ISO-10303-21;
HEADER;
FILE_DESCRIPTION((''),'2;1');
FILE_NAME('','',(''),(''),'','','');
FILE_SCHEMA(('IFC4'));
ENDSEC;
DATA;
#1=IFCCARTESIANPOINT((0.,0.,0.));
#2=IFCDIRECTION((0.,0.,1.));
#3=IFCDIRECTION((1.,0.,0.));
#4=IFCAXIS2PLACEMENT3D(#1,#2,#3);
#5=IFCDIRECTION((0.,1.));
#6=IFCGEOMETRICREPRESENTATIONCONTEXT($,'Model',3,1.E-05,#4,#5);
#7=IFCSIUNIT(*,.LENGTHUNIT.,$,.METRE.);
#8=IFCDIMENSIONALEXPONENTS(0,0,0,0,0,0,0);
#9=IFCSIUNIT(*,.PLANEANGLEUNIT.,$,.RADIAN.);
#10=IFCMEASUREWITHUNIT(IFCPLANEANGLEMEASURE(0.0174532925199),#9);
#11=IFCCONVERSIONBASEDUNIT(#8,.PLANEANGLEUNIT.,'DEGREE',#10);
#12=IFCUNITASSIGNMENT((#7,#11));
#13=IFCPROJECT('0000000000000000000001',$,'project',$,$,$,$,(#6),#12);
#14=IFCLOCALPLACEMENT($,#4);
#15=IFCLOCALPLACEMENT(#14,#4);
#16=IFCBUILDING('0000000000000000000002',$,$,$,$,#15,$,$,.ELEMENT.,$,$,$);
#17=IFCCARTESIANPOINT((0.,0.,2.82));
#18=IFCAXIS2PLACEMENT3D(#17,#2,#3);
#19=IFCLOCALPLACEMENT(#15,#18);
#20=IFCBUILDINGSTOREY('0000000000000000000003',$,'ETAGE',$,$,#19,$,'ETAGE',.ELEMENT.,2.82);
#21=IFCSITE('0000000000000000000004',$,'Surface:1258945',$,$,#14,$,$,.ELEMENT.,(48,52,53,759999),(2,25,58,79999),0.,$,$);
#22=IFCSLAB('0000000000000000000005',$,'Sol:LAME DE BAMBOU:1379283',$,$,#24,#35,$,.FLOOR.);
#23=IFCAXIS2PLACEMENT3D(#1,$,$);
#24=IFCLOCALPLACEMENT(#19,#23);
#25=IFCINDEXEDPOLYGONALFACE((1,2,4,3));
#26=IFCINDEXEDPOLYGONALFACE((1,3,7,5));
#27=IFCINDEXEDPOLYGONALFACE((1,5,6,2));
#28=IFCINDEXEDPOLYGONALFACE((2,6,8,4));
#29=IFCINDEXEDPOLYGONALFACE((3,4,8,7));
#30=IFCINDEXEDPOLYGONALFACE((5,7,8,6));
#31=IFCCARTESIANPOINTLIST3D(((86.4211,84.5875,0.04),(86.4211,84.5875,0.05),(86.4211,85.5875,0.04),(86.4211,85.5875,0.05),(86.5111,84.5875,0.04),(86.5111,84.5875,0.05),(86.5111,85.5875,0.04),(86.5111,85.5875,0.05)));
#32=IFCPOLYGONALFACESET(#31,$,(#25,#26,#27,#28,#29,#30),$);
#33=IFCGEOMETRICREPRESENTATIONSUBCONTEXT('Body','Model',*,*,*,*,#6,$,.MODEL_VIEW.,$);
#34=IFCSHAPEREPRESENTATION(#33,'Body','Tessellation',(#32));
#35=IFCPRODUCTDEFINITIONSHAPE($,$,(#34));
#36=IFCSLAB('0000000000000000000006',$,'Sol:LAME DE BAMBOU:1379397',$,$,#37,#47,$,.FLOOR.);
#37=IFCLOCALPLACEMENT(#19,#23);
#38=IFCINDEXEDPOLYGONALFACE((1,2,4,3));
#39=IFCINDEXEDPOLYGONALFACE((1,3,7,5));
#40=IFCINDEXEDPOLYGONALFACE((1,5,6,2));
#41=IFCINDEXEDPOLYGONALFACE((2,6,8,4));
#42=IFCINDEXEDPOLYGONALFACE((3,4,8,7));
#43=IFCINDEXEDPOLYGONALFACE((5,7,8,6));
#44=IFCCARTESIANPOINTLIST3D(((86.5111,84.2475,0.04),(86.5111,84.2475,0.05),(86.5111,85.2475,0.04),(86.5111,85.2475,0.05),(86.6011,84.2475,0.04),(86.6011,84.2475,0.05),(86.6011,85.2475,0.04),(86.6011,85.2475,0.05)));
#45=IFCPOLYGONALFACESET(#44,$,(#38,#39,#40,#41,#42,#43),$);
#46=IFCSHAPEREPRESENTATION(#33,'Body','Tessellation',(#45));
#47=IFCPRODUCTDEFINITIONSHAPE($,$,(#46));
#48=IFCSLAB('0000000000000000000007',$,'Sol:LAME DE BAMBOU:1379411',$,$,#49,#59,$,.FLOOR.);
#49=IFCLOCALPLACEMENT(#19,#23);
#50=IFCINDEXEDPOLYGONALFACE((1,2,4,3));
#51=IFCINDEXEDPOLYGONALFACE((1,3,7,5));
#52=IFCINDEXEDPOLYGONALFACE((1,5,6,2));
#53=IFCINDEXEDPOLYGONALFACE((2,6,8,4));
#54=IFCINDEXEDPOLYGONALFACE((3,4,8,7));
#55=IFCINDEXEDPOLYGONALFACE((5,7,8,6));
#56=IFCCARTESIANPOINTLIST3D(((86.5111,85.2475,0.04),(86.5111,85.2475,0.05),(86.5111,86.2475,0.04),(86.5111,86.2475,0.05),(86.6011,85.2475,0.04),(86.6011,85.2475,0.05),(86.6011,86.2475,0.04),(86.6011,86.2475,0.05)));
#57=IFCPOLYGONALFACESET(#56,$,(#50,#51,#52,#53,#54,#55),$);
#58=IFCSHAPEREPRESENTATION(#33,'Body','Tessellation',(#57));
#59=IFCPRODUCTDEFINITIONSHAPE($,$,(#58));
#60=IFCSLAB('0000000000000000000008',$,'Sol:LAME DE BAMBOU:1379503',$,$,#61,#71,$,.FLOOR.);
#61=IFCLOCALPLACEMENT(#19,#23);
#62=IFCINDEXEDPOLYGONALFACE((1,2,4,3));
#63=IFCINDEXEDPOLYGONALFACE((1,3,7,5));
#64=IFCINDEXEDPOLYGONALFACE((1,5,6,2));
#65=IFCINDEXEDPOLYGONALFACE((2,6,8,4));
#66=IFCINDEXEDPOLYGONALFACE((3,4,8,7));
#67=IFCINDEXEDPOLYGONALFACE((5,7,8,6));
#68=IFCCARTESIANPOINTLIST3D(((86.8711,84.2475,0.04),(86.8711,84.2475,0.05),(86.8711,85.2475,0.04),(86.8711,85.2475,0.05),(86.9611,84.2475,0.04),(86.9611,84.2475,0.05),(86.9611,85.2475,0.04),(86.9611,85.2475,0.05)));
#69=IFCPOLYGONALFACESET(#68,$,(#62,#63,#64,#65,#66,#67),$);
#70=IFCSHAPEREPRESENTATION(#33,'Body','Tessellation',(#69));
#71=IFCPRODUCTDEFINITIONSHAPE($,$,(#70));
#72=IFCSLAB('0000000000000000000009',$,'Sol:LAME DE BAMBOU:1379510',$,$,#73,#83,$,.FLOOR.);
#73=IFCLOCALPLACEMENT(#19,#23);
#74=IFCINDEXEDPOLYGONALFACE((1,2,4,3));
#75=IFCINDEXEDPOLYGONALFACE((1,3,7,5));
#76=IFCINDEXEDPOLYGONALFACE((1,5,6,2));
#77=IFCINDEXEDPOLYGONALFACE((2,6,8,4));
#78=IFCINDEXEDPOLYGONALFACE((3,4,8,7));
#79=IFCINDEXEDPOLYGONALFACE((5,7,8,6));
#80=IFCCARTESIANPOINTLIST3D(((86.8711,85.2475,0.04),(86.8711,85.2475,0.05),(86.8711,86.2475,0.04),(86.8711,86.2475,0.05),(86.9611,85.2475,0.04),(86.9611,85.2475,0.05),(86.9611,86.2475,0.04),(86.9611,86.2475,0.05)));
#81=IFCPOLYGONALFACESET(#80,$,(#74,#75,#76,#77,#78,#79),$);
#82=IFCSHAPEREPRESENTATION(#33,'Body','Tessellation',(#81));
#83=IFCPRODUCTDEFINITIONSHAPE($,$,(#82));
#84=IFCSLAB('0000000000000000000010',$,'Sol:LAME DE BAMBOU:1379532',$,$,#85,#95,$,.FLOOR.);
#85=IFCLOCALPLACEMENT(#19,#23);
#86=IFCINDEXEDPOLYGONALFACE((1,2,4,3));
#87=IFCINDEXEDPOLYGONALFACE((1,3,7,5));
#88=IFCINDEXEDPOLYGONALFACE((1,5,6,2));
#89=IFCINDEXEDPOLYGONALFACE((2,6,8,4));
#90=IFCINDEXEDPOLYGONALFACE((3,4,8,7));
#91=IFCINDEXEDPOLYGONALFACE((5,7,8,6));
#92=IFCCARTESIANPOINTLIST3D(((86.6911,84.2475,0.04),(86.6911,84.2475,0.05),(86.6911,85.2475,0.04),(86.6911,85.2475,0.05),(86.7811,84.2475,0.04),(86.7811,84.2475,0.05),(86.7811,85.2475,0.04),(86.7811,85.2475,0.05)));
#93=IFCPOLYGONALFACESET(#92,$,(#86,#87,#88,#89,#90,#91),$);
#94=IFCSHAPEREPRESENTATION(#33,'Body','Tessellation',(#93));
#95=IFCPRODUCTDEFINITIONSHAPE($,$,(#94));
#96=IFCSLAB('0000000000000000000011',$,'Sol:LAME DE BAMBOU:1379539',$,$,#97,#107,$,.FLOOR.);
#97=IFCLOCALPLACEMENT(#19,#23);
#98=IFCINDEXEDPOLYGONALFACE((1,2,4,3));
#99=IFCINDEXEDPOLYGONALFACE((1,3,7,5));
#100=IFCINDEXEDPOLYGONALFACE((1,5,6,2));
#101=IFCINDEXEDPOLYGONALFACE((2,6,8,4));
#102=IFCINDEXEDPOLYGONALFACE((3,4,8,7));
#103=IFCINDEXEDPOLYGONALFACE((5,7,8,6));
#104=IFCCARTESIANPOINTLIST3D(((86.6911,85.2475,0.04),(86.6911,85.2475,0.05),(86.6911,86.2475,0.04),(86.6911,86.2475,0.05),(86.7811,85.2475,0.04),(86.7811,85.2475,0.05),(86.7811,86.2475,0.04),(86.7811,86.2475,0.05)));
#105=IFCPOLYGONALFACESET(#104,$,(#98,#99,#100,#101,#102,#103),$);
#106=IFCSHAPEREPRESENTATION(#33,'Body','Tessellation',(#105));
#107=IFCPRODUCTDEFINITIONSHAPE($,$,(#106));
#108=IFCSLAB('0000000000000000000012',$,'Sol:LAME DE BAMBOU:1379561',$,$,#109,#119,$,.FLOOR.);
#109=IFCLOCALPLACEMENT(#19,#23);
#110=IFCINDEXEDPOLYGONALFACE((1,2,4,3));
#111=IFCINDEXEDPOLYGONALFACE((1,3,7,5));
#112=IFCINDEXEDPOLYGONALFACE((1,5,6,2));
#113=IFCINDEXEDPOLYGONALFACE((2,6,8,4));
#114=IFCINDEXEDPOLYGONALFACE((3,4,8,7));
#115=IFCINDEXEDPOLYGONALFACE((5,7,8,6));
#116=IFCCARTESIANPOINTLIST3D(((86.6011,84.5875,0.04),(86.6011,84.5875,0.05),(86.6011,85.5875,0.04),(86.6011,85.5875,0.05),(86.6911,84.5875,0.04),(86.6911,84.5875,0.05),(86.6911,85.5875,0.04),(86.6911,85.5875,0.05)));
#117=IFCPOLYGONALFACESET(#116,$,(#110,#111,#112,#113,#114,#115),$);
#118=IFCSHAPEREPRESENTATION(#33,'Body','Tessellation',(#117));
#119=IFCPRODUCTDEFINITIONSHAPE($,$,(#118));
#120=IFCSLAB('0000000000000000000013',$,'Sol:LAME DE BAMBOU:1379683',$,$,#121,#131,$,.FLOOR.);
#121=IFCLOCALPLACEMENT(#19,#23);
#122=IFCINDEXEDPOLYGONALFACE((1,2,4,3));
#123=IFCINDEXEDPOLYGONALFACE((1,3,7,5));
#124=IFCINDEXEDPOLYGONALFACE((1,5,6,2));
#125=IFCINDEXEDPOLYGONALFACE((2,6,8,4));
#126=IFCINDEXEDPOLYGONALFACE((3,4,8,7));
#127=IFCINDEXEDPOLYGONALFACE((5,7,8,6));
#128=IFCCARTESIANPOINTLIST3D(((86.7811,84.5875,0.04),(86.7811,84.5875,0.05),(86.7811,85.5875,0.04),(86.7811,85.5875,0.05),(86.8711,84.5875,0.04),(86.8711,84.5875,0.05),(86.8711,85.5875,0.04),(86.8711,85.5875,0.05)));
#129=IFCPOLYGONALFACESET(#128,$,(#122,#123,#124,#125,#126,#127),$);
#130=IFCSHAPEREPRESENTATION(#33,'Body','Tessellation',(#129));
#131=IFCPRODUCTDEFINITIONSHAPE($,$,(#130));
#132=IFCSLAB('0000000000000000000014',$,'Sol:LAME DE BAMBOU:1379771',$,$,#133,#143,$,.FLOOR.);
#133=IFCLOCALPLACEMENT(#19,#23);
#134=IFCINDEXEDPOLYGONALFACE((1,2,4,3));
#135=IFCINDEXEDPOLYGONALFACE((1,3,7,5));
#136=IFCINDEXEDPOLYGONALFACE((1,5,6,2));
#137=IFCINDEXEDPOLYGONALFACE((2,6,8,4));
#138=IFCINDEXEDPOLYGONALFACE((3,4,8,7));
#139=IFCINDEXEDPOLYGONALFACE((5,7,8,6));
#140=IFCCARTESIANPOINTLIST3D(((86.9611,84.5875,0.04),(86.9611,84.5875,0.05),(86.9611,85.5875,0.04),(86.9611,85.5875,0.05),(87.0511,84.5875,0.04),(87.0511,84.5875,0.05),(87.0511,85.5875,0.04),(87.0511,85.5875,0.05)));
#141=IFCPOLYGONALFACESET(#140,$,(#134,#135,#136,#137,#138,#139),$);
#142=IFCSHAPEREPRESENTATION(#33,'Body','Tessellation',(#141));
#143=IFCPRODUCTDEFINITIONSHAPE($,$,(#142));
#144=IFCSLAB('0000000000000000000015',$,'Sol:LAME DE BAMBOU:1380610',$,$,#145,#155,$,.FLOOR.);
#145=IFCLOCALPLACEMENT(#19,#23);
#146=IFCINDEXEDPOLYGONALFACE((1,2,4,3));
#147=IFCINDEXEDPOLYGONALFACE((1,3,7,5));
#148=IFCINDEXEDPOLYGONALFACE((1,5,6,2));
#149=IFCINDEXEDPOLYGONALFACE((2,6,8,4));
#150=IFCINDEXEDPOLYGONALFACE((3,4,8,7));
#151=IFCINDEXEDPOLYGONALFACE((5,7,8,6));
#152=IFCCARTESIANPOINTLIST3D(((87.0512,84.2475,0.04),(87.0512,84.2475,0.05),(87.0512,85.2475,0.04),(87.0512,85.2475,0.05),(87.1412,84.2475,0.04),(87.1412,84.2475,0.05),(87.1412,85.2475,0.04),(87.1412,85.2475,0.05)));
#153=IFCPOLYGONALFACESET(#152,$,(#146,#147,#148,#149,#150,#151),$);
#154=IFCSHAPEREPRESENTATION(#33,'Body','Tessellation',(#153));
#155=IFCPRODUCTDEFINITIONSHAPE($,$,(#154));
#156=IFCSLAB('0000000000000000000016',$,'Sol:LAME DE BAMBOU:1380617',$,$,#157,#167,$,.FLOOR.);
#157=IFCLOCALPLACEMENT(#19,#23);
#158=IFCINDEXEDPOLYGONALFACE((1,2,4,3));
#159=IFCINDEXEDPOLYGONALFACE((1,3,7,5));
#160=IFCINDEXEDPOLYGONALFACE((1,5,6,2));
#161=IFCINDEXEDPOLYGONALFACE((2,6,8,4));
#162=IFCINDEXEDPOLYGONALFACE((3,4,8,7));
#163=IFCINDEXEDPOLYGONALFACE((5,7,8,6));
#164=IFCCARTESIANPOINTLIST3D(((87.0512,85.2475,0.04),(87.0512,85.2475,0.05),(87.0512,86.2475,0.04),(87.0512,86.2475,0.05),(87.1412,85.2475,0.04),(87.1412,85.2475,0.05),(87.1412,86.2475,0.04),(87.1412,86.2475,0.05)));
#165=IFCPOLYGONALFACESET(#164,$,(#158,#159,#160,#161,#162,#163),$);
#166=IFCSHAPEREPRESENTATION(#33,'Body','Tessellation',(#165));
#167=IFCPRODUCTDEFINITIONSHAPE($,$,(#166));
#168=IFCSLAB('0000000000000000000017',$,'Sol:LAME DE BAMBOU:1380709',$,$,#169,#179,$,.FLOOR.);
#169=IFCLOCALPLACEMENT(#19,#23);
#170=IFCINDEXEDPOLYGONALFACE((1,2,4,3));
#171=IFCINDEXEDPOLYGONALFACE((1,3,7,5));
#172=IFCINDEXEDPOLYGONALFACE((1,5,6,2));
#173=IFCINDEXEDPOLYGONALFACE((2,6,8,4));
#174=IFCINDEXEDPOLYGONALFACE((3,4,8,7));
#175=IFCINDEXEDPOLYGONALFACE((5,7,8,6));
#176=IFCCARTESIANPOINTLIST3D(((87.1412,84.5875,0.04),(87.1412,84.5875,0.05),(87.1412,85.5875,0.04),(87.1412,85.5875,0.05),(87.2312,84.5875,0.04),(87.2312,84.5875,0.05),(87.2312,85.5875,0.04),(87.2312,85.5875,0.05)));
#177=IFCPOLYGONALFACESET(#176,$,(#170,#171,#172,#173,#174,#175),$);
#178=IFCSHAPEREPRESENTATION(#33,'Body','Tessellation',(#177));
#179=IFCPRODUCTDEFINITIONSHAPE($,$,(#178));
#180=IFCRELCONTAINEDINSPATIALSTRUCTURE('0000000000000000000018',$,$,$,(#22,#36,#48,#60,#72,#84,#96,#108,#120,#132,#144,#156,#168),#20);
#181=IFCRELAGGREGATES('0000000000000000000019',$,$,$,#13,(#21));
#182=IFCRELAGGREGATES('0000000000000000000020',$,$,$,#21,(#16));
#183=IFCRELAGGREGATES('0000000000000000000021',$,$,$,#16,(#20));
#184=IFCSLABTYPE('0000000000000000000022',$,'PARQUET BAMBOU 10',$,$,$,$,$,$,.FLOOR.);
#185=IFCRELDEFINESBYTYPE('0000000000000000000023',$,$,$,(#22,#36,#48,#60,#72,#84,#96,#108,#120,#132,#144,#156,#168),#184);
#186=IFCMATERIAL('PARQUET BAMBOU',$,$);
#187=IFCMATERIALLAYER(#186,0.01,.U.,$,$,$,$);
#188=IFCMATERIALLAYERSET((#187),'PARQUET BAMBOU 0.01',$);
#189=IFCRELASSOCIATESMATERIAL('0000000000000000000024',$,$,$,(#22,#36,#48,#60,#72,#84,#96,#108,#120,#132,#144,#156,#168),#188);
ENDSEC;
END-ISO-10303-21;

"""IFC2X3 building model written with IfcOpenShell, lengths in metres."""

from ifc_helpers import new_model, entity, si_unit, converted_unit, direction, frame, origin_with_axes, place, context, subcontext, project, spatial, polyline, outline, extrude, material, layer, layer_set, layer_usage, type_object, element, save


model = new_model("IFC2X3")

# Units and contexts
model_context = context("Model", 3, precision=1e-05, world=origin_with_axes(), true_north=direction((0.0, 1.0)))
body_context = subcontext(model_context, "Body", "Model", "MODEL_VIEW")
ifc_project = project(units=[si_unit("LENGTHUNIT", "METRE"), converted_unit("PLANEANGLEUNIT", "DEGREE", entity("IfcPlaneAngleMeasure", 0.0174532925199), si_unit("PLANEANGLEUNIT", "RADIAN"), dimensions=[0, 0, 0, 0, 0, 0, 0])], contexts=[model_context])

# Site, building, storey
site_placement = place(None, origin_with_axes())
site = spatial("IfcSite", under=ifc_project, at=site_placement, Name="Surface:1258945", CompositionType="ELEMENT", RefLatitude=(48, 52, 53, 759999), RefLongitude=(2, 25, 58, 79999), RefElevation=0.0)
building_placement = place(site_placement, origin_with_axes())
building = spatial("IfcBuilding", under=site, at=building_placement, CompositionType="ELEMENT")
storey_placement = place(building_placement, frame((0.0, 0.0, 2.82), z_axis=(0.0, 0.0, 1.0), x_axis=(1.0, 0.0, 0.0)))
storey = spatial("IfcBuildingStorey", under=building, at=storey_placement, Name="ETAGE", LongName="ETAGE", CompositionType="ELEMENT", Elevation=2.82)

# Slabs
ifc_material_1 = material(Name="PARQUET BAMBOU")
ifc_layer_1 = layer(ifc_material_1, 0.01, ventilated="UNKNOWN")
ifc_layer_set_1 = layer_set([ifc_layer_1], Name="PARQUET BAMBOU 0.01")
ifc_layer_usage_1 = layer_usage(ifc_layer_set_1, "AXIS3", "NEGATIVE", 0.01)
slab_type = type_object("IfcSlabType", Name="PARQUET BAMBOU 10", PredefinedType="FLOOR")
slab_1_placement = place(storey_placement, frame((86.4211, 85.5875, 0.05), z_axis=(0.0, 0.0, 1.0), x_axis=(1.0, 0.0, 0.0)))
element("IfcSlab", 1, at=slab_1_placement, inside=storey, type_object=slab_type, material=ifc_layer_usage_1, Name="Sol:LAME DE BAMBOU:1379283", PredefinedType="FLOOR", context=body_context, shape_type="SweptSolid", body=[
    extrude(outline(polyline([(0.0, 0.0), (0.0, -1.0), (0.09, -1.0), (0.09, 0.0), (0.0, 0.0)])), frame((0.0, 0.0, -0.01), z_axis=(0.0, 0.0, 1.0), x_axis=(1.0, 0.0, 0.0)), (0.0, 0.0, 1.0), 0.01),
])
ifc_layer_usage_2 = layer_usage(ifc_layer_set_1, "AXIS3", "NEGATIVE", 0.01)
slab_2_placement = place(storey_placement, frame((86.5111, 85.2475, 0.05), z_axis=(0.0, 0.0, 1.0), x_axis=(1.0, 0.0, 0.0)))
element("IfcSlab", 2, at=slab_2_placement, inside=storey, type_object=slab_type, material=ifc_layer_usage_2, Name="Sol:LAME DE BAMBOU:1379397", PredefinedType="FLOOR", context=body_context, shape_type="SweptSolid", body=[
    extrude(outline(polyline([(0.0, 0.0), (0.0, -1.0), (0.09, -1.0), (0.09, 0.0), (0.0, 0.0)])), frame((0.0, 0.0, -0.01), z_axis=(0.0, 0.0, 1.0), x_axis=(1.0, 0.0, 0.0)), (0.0, 0.0, 1.0), 0.01),
])
ifc_layer_usage_3 = layer_usage(ifc_layer_set_1, "AXIS3", "NEGATIVE", 0.01)
slab_3_placement = place(storey_placement, frame((86.5111, 86.2475, 0.05), z_axis=(0.0, 0.0, 1.0), x_axis=(1.0, 0.0, 0.0)))
element("IfcSlab", 3, at=slab_3_placement, inside=storey, type_object=slab_type, material=ifc_layer_usage_3, Name="Sol:LAME DE BAMBOU:1379411", PredefinedType="FLOOR", context=body_context, shape_type="SweptSolid", body=[
    extrude(outline(polyline([(0.0, 0.0), (0.0, -1.0), (0.09, -1.0), (0.09, 0.0), (0.0, 0.0)])), frame((0.0, 0.0, -0.01), z_axis=(0.0, 0.0, 1.0), x_axis=(1.0, 0.0, 0.0)), (0.0, 0.0, 1.0), 0.01),
])
ifc_layer_usage_4 = layer_usage(ifc_layer_set_1, "AXIS3", "NEGATIVE", 0.01)
slab_4_placement = place(storey_placement, frame((86.8711, 85.2475, 0.05), z_axis=(0.0, 0.0, 1.0), x_axis=(1.0, 0.0, 0.0)))
element("IfcSlab", 4, at=slab_4_placement, inside=storey, type_object=slab_type, material=ifc_layer_usage_4, Name="Sol:LAME DE BAMBOU:1379503", PredefinedType="FLOOR", context=body_context, shape_type="SweptSolid", body=[
    extrude(outline(polyline([(0.0, 0.0), (0.0, -1.0), (0.09, -1.0), (0.09, 0.0), (0.0, 0.0)])), frame((0.0, 0.0, -0.01), z_axis=(0.0, 0.0, 1.0), x_axis=(1.0, 0.0, 0.0)), (0.0, 0.0, 1.0), 0.01),
])
ifc_layer_usage_5 = layer_usage(ifc_layer_set_1, "AXIS3", "NEGATIVE", 0.01)
slab_5_placement = place(storey_placement, frame((86.8711, 86.2475, 0.05), z_axis=(0.0, 0.0, 1.0), x_axis=(1.0, 0.0, 0.0)))
element("IfcSlab", 5, at=slab_5_placement, inside=storey, type_object=slab_type, material=ifc_layer_usage_5, Name="Sol:LAME DE BAMBOU:1379510", PredefinedType="FLOOR", context=body_context, shape_type="SweptSolid", body=[
    extrude(outline(polyline([(0.0, 0.0), (0.0, -1.0), (0.09, -1.0), (0.09, 0.0), (0.0, 0.0)])), frame((0.0, 0.0, -0.01), z_axis=(0.0, 0.0, 1.0), x_axis=(1.0, 0.0, 0.0)), (0.0, 0.0, 1.0), 0.01),
])
ifc_layer_usage_6 = layer_usage(ifc_layer_set_1, "AXIS3", "NEGATIVE", 0.01)
slab_6_placement = place(storey_placement, frame((86.6911, 85.2475, 0.05), z_axis=(0.0, 0.0, 1.0), x_axis=(1.0, 0.0, 0.0)))
element("IfcSlab", 6, at=slab_6_placement, inside=storey, type_object=slab_type, material=ifc_layer_usage_6, Name="Sol:LAME DE BAMBOU:1379532", PredefinedType="FLOOR", context=body_context, shape_type="SweptSolid", body=[
    extrude(outline(polyline([(0.0, 0.0), (0.0, -1.0), (0.09, -1.0), (0.09, 0.0), (0.0, 0.0)])), frame((0.0, 0.0, -0.01), z_axis=(0.0, 0.0, 1.0), x_axis=(1.0, 0.0, 0.0)), (0.0, 0.0, 1.0), 0.01),
])
ifc_layer_usage_7 = layer_usage(ifc_layer_set_1, "AXIS3", "NEGATIVE", 0.01)
slab_7_placement = place(storey_placement, frame((86.6911, 86.2475, 0.05), z_axis=(0.0, 0.0, 1.0), x_axis=(1.0, 0.0, 0.0)))
element("IfcSlab", 7, at=slab_7_placement, inside=storey, type_object=slab_type, material=ifc_layer_usage_7, Name="Sol:LAME DE BAMBOU:1379539", PredefinedType="FLOOR", context=body_context, shape_type="SweptSolid", body=[
    extrude(outline(polyline([(0.0, 0.0), (0.0, -1.0), (0.09, -1.0), (0.09, 0.0), (0.0, 0.0)])), frame((0.0, 0.0, -0.01), z_axis=(0.0, 0.0, 1.0), x_axis=(1.0, 0.0, 0.0)), (0.0, 0.0, 1.0), 0.01),
])
ifc_layer_usage_8 = layer_usage(ifc_layer_set_1, "AXIS3", "NEGATIVE", 0.01)
slab_8_placement = place(storey_placement, frame((86.6011, 85.5875, 0.05), z_axis=(0.0, 0.0, 1.0), x_axis=(1.0, 0.0, 0.0)))
element("IfcSlab", 8, at=slab_8_placement, inside=storey, type_object=slab_type, material=ifc_layer_usage_8, Name="Sol:LAME DE BAMBOU:1379561", PredefinedType="FLOOR", context=body_context, shape_type="SweptSolid", body=[
    extrude(outline(polyline([(0.0, 0.0), (0.0, -1.0), (0.09, -1.0), (0.09, 0.0), (0.0, 0.0)])), frame((0.0, 0.0, -0.01), z_axis=(0.0, 0.0, 1.0), x_axis=(1.0, 0.0, 0.0)), (0.0, 0.0, 1.0), 0.01),
])
ifc_layer_usage_9 = layer_usage(ifc_layer_set_1, "AXIS3", "NEGATIVE", 0.01)
slab_9_placement = place(storey_placement, frame((86.7811, 85.5875, 0.05), z_axis=(0.0, 0.0, 1.0), x_axis=(1.0, 0.0, 0.0)))
element("IfcSlab", 9, at=slab_9_placement, inside=storey, type_object=slab_type, material=ifc_layer_usage_9, Name="Sol:LAME DE BAMBOU:1379683", PredefinedType="FLOOR", context=body_context, shape_type="SweptSolid", body=[
    extrude(outline(polyline([(0.0, 0.0), (0.0, -1.0), (0.09, -1.0), (0.09, 0.0), (0.0, 0.0)])), frame((0.0, 0.0, -0.01), z_axis=(0.0, 0.0, 1.0), x_axis=(1.0, 0.0, 0.0)), (0.0, 0.0, 1.0), 0.01),
])
ifc_layer_usage_10 = layer_usage(ifc_layer_set_1, "AXIS3", "NEGATIVE", 0.01)
slab_10_placement = place(storey_placement, frame((86.9611, 85.5875, 0.05), z_axis=(0.0, 0.0, 1.0), x_axis=(1.0, 0.0, 0.0)))
element("IfcSlab", 10, at=slab_10_placement, inside=storey, type_object=slab_type, material=ifc_layer_usage_10, Name="Sol:LAME DE BAMBOU:1379771", PredefinedType="FLOOR", context=body_context, shape_type="SweptSolid", body=[
    extrude(outline(polyline([(0.0, 0.0), (0.0, -1.0), (0.09, -1.0), (0.09, 0.0), (0.0, 0.0)])), frame((0.0, 0.0, -0.01), z_axis=(0.0, 0.0, 1.0), x_axis=(1.0, 0.0, 0.0)), (0.0, 0.0, 1.0), 0.01),
])
ifc_layer_usage_11 = layer_usage(ifc_layer_set_1, "AXIS3", "NEGATIVE", 0.01)
slab_11_placement = place(storey_placement, frame((87.0512, 85.2475, 0.05), z_axis=(0.0, 0.0, 1.0), x_axis=(1.0, 0.0, 0.0)))
element("IfcSlab", 11, at=slab_11_placement, inside=storey, type_object=slab_type, material=ifc_layer_usage_11, Name="Sol:LAME DE BAMBOU:1380610", PredefinedType="FLOOR", context=body_context, shape_type="SweptSolid", body=[
    extrude(outline(polyline([(0.0, 0.0), (0.0, -1.0), (0.09, -1.0), (0.09, 0.0), (0.0, 0.0)])), frame((0.0, 0.0, -0.01), z_axis=(0.0, 0.0, 1.0), x_axis=(1.0, 0.0, 0.0)), (0.0, 0.0, 1.0), 0.01),
])
ifc_layer_usage_12 = layer_usage(ifc_layer_set_1, "AXIS3", "NEGATIVE", 0.01)
slab_12_placement = place(storey_placement, frame((87.0512, 86.2475, 0.05), z_axis=(0.0, 0.0, 1.0), x_axis=(1.0, 0.0, 0.0)))
element("IfcSlab", 12, at=slab_12_placement, inside=storey, type_object=slab_type, material=ifc_layer_usage_12, Name="Sol:LAME DE BAMBOU:1380617", PredefinedType="FLOOR", context=body_context, shape_type="SweptSolid", body=[
    extrude(outline(polyline([(0.0, 0.0), (0.0, -1.0), (0.09, -1.0), (0.09, 0.0), (0.0, 0.0)])), frame((0.0, 0.0, -0.01), z_axis=(0.0, 0.0, 1.0), x_axis=(1.0, 0.0, 0.0)), (0.0, 0.0, 1.0), 0.01),
])
ifc_layer_usage_13 = layer_usage(ifc_layer_set_1, "AXIS3", "NEGATIVE", 0.01)
slab_13_placement = place(storey_placement, frame((87.1412, 85.5875, 0.05), z_axis=(0.0, 0.0, 1.0), x_axis=(1.0, 0.0, 0.0)))
element("IfcSlab", 13, at=slab_13_placement, inside=storey, type_object=slab_type, material=ifc_layer_usage_13, Name="Sol:LAME DE BAMBOU:1380709", PredefinedType="FLOOR", context=body_context, shape_type="SweptSolid", body=[
    extrude(outline(polyline([(0.0, 0.0), (0.0, -1.0), (0.09, -1.0), (0.09, 0.0), (0.0, 0.0)])), frame((0.0, 0.0, -0.01), z_axis=(0.0, 0.0, 1.0), x_axis=(1.0, 0.0, 0.0)), (0.0, 0.0, 1.0), 0.01),
])

save(model, "model.ifc")
